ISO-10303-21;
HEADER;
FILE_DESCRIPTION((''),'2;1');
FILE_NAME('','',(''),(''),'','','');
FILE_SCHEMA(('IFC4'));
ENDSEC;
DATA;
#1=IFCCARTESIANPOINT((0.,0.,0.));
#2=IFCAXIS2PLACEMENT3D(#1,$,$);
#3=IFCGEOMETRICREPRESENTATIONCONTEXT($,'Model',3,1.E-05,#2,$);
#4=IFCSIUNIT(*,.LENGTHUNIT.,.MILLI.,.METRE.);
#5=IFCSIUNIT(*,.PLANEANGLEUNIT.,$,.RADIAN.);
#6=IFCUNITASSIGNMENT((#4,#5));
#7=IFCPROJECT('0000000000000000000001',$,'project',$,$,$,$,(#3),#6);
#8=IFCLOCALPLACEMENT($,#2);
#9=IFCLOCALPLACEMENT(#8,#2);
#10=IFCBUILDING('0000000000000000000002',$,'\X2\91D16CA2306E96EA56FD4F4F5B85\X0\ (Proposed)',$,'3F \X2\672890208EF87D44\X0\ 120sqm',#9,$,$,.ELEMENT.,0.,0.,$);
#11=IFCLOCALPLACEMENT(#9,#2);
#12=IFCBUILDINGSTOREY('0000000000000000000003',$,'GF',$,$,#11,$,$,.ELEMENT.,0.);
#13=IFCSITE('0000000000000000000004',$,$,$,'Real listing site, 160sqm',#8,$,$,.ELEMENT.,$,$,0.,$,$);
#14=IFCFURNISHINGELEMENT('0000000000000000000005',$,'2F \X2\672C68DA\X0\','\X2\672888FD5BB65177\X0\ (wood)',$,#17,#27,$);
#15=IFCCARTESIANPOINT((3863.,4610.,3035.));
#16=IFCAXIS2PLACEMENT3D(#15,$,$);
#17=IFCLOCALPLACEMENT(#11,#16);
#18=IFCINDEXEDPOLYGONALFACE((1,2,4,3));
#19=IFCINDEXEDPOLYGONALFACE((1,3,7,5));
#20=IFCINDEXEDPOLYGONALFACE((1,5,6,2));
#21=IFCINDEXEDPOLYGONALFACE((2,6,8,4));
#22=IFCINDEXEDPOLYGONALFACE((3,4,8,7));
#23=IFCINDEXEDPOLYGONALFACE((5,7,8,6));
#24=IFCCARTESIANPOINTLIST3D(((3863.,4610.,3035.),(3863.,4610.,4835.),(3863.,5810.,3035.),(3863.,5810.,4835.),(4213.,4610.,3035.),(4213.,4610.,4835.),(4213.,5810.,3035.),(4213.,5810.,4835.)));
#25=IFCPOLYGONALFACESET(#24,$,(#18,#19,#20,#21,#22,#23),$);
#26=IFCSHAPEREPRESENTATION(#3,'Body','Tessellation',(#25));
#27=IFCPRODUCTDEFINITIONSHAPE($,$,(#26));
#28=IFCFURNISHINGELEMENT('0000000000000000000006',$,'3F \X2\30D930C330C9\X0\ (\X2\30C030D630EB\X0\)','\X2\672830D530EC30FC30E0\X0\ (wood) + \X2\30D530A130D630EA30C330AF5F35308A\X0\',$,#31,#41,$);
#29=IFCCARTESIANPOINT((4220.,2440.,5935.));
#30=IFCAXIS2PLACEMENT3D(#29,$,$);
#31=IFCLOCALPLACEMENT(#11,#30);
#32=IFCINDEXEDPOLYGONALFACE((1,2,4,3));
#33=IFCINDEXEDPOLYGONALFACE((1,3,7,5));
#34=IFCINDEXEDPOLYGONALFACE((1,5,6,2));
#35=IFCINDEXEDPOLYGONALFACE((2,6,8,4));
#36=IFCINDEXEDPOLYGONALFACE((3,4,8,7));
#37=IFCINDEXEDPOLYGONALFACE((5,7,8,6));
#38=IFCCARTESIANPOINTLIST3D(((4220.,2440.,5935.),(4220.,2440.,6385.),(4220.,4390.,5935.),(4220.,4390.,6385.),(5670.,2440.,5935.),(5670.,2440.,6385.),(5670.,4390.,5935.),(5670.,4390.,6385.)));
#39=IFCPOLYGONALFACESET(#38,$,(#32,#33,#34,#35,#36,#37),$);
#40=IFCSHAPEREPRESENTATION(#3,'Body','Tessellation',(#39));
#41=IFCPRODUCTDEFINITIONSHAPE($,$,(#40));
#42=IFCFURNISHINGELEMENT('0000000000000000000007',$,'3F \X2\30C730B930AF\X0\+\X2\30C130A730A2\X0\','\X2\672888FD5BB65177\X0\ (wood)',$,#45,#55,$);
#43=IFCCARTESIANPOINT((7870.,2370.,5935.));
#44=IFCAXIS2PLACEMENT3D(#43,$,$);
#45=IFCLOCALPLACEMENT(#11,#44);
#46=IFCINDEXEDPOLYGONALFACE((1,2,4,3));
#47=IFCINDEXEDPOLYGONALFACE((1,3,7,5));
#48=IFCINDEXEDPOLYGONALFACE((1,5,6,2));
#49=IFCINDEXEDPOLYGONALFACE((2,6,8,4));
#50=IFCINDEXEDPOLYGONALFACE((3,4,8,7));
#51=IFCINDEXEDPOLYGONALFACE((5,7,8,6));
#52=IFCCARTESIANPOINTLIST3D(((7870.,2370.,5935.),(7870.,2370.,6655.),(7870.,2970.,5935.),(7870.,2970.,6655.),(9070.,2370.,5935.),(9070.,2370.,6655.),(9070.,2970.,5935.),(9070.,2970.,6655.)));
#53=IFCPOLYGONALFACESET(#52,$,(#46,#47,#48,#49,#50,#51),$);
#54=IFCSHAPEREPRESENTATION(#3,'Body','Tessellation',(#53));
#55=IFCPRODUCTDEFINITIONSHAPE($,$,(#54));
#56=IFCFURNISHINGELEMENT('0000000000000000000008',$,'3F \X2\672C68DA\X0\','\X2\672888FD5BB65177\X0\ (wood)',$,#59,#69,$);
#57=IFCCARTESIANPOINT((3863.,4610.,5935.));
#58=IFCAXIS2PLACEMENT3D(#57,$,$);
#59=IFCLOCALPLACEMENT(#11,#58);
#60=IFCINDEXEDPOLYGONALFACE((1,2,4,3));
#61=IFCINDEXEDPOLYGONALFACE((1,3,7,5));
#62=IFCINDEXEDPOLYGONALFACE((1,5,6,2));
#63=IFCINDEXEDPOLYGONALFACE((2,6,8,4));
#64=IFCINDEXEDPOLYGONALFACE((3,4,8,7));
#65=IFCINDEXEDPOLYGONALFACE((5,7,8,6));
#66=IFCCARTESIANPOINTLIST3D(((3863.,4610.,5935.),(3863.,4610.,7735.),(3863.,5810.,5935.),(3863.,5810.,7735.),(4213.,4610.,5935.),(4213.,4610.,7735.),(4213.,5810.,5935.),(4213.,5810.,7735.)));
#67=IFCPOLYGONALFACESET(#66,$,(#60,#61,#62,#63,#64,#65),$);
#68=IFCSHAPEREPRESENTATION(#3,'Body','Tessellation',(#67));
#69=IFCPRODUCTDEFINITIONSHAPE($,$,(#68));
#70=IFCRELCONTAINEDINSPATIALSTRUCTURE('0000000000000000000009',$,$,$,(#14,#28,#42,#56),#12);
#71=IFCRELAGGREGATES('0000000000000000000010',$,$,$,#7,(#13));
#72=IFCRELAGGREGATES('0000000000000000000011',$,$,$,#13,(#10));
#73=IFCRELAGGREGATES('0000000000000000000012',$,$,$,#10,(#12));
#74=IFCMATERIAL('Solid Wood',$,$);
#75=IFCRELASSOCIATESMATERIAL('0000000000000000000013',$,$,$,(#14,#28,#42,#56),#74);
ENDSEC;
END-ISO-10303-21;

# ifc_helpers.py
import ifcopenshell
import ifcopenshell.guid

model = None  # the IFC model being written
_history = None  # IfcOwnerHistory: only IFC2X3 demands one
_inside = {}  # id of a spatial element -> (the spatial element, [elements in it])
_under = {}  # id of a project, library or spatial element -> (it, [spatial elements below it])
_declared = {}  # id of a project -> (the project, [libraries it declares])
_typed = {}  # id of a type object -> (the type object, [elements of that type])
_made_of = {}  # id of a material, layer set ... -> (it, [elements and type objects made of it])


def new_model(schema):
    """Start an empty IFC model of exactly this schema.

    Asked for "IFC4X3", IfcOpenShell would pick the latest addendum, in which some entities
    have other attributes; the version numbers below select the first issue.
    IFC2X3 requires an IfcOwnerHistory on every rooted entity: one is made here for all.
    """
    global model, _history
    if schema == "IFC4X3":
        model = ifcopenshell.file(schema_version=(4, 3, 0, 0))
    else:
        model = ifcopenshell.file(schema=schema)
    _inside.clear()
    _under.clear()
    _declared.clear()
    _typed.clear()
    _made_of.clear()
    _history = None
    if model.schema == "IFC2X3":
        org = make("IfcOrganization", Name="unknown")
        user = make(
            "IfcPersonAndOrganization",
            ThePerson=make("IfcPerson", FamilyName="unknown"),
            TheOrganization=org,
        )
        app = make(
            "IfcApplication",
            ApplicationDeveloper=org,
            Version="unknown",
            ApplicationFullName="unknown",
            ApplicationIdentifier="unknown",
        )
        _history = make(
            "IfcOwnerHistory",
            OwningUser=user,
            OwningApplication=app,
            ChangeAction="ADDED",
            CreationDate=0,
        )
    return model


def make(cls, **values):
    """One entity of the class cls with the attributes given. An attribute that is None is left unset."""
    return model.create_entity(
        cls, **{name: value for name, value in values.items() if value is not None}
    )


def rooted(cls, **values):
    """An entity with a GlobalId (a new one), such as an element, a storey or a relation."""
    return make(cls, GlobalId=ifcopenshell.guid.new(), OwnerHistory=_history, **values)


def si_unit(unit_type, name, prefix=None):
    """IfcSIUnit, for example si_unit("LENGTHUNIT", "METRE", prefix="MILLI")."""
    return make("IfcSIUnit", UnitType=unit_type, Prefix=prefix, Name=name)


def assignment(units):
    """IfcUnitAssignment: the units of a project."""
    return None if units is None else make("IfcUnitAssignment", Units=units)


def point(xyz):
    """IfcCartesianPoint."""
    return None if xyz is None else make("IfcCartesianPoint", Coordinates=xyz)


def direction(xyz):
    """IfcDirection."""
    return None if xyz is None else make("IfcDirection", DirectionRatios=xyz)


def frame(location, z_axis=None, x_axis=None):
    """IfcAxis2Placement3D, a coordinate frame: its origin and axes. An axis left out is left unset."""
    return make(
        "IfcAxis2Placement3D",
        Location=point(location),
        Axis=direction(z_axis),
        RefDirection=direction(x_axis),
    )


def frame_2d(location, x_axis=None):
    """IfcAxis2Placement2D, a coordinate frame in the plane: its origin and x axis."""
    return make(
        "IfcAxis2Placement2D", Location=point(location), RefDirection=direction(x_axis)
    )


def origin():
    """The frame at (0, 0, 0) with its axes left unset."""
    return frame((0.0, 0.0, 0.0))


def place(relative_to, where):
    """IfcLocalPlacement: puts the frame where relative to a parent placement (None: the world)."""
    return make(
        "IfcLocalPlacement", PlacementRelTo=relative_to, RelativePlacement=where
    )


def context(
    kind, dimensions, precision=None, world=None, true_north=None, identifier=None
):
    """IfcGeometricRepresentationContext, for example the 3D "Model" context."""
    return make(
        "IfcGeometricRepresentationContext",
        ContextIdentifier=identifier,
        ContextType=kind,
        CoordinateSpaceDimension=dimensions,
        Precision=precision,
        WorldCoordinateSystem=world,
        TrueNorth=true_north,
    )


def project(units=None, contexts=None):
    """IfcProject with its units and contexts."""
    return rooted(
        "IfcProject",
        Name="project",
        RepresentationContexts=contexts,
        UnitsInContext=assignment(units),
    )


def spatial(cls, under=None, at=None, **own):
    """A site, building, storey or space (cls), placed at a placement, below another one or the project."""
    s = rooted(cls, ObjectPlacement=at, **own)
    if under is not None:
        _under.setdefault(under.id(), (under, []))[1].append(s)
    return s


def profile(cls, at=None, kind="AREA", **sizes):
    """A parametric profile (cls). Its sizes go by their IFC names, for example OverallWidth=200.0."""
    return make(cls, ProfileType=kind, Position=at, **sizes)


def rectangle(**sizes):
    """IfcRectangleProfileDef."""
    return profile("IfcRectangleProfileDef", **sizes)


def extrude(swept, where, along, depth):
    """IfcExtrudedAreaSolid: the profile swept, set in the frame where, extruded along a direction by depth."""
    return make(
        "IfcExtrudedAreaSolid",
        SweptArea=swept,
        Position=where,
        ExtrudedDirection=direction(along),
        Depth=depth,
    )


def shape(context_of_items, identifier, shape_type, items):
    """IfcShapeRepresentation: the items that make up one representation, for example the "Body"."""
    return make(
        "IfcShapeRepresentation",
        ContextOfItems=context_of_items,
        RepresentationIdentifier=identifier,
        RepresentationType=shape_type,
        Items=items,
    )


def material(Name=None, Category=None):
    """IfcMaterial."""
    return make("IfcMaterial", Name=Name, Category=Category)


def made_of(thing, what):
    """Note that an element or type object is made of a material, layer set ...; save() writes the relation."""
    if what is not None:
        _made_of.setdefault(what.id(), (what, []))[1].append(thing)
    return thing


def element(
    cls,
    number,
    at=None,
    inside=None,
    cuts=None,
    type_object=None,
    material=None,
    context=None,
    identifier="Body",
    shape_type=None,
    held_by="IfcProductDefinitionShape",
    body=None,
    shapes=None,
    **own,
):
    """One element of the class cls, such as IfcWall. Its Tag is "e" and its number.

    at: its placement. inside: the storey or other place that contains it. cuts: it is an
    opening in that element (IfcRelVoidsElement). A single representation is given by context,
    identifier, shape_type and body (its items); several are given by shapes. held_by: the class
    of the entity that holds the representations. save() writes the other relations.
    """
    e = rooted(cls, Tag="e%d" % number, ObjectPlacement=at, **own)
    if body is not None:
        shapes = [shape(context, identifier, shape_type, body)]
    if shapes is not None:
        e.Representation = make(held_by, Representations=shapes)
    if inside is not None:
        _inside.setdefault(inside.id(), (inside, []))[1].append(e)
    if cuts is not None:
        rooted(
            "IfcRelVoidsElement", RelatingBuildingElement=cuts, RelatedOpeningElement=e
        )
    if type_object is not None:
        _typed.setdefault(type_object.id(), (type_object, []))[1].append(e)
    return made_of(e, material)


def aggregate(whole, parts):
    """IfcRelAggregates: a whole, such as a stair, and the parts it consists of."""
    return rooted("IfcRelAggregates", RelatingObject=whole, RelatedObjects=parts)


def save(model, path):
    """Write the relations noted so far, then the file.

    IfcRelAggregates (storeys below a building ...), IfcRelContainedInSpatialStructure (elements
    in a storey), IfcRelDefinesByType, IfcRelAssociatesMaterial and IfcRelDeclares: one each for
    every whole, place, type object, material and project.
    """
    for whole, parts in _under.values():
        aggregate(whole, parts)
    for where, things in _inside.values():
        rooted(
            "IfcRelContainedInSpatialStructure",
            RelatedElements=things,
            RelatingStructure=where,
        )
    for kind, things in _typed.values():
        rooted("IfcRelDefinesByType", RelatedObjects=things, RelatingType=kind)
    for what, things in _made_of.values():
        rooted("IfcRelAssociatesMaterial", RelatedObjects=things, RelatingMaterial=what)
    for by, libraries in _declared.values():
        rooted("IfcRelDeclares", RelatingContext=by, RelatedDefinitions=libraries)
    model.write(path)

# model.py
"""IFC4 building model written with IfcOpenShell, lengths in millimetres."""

from ifc_helpers import new_model, si_unit, frame, frame_2d, origin, place, context, project, spatial, rectangle, extrude, material, element, save


model = new_model("IFC4")

# Units and contexts
model_context = context("Model", 3, precision=1e-05, world=origin())
ifc_project = project(units=[si_unit("LENGTHUNIT", "METRE", prefix="MILLI"), si_unit("PLANEANGLEUNIT", "RADIAN")], contexts=[model_context])

# Site, building, storey
site_placement = place(None, origin())
site = spatial("IfcSite", under=ifc_project, at=site_placement, ObjectType="Real listing site, 160sqm", CompositionType="ELEMENT", RefElevation=0.0)
building_placement = place(site_placement, origin())
building = spatial("IfcBuilding", under=site, at=building_placement, Name="金沢の雪国住宅 (Proposed)", ObjectType="3F 木造軸組 120sqm", CompositionType="ELEMENT", ElevationOfRefHeight=0.0, ElevationOfTerrain=0.0)
storey_placement = place(building_placement, origin())
storey = spatial("IfcBuildingStorey", under=building, at=storey_placement, Name="GF", CompositionType="ELEMENT", Elevation=0.0)

# Shared definitions
ifc_material_1 = material(Name="Solid Wood")

# Furnishing elements
furnishing_1_placement = place(storey_placement, frame((3863.0, 4610.0, 3035.0)))
element("IfcFurnishingElement", 1, at=furnishing_1_placement, inside=storey, material=ifc_material_1, Name="2F 本棚", Description="木製家具 (wood)", context=model_context, shape_type="SweptSolid", body=[
    extrude(rectangle(XDim=350.0, YDim=1200.0, at=frame_2d((175.0, 600.0))), frame((3863.0, 4610.0, 3035.0)), (0.0, 0.0, 1.0), 1800.0),
])
furnishing_2_placement = place(storey_placement, frame((4220.0, 2440.0, 5935.0)))
element("IfcFurnishingElement", 2, at=furnishing_2_placement, inside=storey, material=ifc_material_1, Name="3F ベッド (ダブル)", Description="木フレーム (wood) + ファブリック張り", context=model_context, shape_type="SweptSolid", body=[
    extrude(rectangle(XDim=1450.0, YDim=1950.0, at=frame_2d((725.0, 975.0))), frame((4220.0, 2440.0, 5935.0)), (0.0, 0.0, 1.0), 450.0),
])
furnishing_3_placement = place(storey_placement, frame((7870.0, 2370.0, 5935.0)))
element("IfcFurnishingElement", 3, at=furnishing_3_placement, inside=storey, material=ifc_material_1, Name="3F デスク+チェア", Description="木製家具 (wood)", context=model_context, shape_type="SweptSolid", body=[
    extrude(rectangle(XDim=1200.0, YDim=600.0, at=frame_2d((600.0, 300.0))), frame((7870.0, 2370.0, 5935.0)), (0.0, 0.0, 1.0), 720.0),
])
furnishing_4_placement = place(storey_placement, frame((3863.0, 4610.0, 5935.0)))
element("IfcFurnishingElement", 4, at=furnishing_4_placement, inside=storey, material=ifc_material_1, Name="3F 本棚", Description="木製家具 (wood)", context=model_context, shape_type="SweptSolid", body=[
    extrude(rectangle(XDim=350.0, YDim=1200.0, at=frame_2d((175.0, 600.0))), frame((3863.0, 4610.0, 5935.0)), (0.0, 0.0, 1.0), 1800.0),
])

save(model, "model.ifc")
